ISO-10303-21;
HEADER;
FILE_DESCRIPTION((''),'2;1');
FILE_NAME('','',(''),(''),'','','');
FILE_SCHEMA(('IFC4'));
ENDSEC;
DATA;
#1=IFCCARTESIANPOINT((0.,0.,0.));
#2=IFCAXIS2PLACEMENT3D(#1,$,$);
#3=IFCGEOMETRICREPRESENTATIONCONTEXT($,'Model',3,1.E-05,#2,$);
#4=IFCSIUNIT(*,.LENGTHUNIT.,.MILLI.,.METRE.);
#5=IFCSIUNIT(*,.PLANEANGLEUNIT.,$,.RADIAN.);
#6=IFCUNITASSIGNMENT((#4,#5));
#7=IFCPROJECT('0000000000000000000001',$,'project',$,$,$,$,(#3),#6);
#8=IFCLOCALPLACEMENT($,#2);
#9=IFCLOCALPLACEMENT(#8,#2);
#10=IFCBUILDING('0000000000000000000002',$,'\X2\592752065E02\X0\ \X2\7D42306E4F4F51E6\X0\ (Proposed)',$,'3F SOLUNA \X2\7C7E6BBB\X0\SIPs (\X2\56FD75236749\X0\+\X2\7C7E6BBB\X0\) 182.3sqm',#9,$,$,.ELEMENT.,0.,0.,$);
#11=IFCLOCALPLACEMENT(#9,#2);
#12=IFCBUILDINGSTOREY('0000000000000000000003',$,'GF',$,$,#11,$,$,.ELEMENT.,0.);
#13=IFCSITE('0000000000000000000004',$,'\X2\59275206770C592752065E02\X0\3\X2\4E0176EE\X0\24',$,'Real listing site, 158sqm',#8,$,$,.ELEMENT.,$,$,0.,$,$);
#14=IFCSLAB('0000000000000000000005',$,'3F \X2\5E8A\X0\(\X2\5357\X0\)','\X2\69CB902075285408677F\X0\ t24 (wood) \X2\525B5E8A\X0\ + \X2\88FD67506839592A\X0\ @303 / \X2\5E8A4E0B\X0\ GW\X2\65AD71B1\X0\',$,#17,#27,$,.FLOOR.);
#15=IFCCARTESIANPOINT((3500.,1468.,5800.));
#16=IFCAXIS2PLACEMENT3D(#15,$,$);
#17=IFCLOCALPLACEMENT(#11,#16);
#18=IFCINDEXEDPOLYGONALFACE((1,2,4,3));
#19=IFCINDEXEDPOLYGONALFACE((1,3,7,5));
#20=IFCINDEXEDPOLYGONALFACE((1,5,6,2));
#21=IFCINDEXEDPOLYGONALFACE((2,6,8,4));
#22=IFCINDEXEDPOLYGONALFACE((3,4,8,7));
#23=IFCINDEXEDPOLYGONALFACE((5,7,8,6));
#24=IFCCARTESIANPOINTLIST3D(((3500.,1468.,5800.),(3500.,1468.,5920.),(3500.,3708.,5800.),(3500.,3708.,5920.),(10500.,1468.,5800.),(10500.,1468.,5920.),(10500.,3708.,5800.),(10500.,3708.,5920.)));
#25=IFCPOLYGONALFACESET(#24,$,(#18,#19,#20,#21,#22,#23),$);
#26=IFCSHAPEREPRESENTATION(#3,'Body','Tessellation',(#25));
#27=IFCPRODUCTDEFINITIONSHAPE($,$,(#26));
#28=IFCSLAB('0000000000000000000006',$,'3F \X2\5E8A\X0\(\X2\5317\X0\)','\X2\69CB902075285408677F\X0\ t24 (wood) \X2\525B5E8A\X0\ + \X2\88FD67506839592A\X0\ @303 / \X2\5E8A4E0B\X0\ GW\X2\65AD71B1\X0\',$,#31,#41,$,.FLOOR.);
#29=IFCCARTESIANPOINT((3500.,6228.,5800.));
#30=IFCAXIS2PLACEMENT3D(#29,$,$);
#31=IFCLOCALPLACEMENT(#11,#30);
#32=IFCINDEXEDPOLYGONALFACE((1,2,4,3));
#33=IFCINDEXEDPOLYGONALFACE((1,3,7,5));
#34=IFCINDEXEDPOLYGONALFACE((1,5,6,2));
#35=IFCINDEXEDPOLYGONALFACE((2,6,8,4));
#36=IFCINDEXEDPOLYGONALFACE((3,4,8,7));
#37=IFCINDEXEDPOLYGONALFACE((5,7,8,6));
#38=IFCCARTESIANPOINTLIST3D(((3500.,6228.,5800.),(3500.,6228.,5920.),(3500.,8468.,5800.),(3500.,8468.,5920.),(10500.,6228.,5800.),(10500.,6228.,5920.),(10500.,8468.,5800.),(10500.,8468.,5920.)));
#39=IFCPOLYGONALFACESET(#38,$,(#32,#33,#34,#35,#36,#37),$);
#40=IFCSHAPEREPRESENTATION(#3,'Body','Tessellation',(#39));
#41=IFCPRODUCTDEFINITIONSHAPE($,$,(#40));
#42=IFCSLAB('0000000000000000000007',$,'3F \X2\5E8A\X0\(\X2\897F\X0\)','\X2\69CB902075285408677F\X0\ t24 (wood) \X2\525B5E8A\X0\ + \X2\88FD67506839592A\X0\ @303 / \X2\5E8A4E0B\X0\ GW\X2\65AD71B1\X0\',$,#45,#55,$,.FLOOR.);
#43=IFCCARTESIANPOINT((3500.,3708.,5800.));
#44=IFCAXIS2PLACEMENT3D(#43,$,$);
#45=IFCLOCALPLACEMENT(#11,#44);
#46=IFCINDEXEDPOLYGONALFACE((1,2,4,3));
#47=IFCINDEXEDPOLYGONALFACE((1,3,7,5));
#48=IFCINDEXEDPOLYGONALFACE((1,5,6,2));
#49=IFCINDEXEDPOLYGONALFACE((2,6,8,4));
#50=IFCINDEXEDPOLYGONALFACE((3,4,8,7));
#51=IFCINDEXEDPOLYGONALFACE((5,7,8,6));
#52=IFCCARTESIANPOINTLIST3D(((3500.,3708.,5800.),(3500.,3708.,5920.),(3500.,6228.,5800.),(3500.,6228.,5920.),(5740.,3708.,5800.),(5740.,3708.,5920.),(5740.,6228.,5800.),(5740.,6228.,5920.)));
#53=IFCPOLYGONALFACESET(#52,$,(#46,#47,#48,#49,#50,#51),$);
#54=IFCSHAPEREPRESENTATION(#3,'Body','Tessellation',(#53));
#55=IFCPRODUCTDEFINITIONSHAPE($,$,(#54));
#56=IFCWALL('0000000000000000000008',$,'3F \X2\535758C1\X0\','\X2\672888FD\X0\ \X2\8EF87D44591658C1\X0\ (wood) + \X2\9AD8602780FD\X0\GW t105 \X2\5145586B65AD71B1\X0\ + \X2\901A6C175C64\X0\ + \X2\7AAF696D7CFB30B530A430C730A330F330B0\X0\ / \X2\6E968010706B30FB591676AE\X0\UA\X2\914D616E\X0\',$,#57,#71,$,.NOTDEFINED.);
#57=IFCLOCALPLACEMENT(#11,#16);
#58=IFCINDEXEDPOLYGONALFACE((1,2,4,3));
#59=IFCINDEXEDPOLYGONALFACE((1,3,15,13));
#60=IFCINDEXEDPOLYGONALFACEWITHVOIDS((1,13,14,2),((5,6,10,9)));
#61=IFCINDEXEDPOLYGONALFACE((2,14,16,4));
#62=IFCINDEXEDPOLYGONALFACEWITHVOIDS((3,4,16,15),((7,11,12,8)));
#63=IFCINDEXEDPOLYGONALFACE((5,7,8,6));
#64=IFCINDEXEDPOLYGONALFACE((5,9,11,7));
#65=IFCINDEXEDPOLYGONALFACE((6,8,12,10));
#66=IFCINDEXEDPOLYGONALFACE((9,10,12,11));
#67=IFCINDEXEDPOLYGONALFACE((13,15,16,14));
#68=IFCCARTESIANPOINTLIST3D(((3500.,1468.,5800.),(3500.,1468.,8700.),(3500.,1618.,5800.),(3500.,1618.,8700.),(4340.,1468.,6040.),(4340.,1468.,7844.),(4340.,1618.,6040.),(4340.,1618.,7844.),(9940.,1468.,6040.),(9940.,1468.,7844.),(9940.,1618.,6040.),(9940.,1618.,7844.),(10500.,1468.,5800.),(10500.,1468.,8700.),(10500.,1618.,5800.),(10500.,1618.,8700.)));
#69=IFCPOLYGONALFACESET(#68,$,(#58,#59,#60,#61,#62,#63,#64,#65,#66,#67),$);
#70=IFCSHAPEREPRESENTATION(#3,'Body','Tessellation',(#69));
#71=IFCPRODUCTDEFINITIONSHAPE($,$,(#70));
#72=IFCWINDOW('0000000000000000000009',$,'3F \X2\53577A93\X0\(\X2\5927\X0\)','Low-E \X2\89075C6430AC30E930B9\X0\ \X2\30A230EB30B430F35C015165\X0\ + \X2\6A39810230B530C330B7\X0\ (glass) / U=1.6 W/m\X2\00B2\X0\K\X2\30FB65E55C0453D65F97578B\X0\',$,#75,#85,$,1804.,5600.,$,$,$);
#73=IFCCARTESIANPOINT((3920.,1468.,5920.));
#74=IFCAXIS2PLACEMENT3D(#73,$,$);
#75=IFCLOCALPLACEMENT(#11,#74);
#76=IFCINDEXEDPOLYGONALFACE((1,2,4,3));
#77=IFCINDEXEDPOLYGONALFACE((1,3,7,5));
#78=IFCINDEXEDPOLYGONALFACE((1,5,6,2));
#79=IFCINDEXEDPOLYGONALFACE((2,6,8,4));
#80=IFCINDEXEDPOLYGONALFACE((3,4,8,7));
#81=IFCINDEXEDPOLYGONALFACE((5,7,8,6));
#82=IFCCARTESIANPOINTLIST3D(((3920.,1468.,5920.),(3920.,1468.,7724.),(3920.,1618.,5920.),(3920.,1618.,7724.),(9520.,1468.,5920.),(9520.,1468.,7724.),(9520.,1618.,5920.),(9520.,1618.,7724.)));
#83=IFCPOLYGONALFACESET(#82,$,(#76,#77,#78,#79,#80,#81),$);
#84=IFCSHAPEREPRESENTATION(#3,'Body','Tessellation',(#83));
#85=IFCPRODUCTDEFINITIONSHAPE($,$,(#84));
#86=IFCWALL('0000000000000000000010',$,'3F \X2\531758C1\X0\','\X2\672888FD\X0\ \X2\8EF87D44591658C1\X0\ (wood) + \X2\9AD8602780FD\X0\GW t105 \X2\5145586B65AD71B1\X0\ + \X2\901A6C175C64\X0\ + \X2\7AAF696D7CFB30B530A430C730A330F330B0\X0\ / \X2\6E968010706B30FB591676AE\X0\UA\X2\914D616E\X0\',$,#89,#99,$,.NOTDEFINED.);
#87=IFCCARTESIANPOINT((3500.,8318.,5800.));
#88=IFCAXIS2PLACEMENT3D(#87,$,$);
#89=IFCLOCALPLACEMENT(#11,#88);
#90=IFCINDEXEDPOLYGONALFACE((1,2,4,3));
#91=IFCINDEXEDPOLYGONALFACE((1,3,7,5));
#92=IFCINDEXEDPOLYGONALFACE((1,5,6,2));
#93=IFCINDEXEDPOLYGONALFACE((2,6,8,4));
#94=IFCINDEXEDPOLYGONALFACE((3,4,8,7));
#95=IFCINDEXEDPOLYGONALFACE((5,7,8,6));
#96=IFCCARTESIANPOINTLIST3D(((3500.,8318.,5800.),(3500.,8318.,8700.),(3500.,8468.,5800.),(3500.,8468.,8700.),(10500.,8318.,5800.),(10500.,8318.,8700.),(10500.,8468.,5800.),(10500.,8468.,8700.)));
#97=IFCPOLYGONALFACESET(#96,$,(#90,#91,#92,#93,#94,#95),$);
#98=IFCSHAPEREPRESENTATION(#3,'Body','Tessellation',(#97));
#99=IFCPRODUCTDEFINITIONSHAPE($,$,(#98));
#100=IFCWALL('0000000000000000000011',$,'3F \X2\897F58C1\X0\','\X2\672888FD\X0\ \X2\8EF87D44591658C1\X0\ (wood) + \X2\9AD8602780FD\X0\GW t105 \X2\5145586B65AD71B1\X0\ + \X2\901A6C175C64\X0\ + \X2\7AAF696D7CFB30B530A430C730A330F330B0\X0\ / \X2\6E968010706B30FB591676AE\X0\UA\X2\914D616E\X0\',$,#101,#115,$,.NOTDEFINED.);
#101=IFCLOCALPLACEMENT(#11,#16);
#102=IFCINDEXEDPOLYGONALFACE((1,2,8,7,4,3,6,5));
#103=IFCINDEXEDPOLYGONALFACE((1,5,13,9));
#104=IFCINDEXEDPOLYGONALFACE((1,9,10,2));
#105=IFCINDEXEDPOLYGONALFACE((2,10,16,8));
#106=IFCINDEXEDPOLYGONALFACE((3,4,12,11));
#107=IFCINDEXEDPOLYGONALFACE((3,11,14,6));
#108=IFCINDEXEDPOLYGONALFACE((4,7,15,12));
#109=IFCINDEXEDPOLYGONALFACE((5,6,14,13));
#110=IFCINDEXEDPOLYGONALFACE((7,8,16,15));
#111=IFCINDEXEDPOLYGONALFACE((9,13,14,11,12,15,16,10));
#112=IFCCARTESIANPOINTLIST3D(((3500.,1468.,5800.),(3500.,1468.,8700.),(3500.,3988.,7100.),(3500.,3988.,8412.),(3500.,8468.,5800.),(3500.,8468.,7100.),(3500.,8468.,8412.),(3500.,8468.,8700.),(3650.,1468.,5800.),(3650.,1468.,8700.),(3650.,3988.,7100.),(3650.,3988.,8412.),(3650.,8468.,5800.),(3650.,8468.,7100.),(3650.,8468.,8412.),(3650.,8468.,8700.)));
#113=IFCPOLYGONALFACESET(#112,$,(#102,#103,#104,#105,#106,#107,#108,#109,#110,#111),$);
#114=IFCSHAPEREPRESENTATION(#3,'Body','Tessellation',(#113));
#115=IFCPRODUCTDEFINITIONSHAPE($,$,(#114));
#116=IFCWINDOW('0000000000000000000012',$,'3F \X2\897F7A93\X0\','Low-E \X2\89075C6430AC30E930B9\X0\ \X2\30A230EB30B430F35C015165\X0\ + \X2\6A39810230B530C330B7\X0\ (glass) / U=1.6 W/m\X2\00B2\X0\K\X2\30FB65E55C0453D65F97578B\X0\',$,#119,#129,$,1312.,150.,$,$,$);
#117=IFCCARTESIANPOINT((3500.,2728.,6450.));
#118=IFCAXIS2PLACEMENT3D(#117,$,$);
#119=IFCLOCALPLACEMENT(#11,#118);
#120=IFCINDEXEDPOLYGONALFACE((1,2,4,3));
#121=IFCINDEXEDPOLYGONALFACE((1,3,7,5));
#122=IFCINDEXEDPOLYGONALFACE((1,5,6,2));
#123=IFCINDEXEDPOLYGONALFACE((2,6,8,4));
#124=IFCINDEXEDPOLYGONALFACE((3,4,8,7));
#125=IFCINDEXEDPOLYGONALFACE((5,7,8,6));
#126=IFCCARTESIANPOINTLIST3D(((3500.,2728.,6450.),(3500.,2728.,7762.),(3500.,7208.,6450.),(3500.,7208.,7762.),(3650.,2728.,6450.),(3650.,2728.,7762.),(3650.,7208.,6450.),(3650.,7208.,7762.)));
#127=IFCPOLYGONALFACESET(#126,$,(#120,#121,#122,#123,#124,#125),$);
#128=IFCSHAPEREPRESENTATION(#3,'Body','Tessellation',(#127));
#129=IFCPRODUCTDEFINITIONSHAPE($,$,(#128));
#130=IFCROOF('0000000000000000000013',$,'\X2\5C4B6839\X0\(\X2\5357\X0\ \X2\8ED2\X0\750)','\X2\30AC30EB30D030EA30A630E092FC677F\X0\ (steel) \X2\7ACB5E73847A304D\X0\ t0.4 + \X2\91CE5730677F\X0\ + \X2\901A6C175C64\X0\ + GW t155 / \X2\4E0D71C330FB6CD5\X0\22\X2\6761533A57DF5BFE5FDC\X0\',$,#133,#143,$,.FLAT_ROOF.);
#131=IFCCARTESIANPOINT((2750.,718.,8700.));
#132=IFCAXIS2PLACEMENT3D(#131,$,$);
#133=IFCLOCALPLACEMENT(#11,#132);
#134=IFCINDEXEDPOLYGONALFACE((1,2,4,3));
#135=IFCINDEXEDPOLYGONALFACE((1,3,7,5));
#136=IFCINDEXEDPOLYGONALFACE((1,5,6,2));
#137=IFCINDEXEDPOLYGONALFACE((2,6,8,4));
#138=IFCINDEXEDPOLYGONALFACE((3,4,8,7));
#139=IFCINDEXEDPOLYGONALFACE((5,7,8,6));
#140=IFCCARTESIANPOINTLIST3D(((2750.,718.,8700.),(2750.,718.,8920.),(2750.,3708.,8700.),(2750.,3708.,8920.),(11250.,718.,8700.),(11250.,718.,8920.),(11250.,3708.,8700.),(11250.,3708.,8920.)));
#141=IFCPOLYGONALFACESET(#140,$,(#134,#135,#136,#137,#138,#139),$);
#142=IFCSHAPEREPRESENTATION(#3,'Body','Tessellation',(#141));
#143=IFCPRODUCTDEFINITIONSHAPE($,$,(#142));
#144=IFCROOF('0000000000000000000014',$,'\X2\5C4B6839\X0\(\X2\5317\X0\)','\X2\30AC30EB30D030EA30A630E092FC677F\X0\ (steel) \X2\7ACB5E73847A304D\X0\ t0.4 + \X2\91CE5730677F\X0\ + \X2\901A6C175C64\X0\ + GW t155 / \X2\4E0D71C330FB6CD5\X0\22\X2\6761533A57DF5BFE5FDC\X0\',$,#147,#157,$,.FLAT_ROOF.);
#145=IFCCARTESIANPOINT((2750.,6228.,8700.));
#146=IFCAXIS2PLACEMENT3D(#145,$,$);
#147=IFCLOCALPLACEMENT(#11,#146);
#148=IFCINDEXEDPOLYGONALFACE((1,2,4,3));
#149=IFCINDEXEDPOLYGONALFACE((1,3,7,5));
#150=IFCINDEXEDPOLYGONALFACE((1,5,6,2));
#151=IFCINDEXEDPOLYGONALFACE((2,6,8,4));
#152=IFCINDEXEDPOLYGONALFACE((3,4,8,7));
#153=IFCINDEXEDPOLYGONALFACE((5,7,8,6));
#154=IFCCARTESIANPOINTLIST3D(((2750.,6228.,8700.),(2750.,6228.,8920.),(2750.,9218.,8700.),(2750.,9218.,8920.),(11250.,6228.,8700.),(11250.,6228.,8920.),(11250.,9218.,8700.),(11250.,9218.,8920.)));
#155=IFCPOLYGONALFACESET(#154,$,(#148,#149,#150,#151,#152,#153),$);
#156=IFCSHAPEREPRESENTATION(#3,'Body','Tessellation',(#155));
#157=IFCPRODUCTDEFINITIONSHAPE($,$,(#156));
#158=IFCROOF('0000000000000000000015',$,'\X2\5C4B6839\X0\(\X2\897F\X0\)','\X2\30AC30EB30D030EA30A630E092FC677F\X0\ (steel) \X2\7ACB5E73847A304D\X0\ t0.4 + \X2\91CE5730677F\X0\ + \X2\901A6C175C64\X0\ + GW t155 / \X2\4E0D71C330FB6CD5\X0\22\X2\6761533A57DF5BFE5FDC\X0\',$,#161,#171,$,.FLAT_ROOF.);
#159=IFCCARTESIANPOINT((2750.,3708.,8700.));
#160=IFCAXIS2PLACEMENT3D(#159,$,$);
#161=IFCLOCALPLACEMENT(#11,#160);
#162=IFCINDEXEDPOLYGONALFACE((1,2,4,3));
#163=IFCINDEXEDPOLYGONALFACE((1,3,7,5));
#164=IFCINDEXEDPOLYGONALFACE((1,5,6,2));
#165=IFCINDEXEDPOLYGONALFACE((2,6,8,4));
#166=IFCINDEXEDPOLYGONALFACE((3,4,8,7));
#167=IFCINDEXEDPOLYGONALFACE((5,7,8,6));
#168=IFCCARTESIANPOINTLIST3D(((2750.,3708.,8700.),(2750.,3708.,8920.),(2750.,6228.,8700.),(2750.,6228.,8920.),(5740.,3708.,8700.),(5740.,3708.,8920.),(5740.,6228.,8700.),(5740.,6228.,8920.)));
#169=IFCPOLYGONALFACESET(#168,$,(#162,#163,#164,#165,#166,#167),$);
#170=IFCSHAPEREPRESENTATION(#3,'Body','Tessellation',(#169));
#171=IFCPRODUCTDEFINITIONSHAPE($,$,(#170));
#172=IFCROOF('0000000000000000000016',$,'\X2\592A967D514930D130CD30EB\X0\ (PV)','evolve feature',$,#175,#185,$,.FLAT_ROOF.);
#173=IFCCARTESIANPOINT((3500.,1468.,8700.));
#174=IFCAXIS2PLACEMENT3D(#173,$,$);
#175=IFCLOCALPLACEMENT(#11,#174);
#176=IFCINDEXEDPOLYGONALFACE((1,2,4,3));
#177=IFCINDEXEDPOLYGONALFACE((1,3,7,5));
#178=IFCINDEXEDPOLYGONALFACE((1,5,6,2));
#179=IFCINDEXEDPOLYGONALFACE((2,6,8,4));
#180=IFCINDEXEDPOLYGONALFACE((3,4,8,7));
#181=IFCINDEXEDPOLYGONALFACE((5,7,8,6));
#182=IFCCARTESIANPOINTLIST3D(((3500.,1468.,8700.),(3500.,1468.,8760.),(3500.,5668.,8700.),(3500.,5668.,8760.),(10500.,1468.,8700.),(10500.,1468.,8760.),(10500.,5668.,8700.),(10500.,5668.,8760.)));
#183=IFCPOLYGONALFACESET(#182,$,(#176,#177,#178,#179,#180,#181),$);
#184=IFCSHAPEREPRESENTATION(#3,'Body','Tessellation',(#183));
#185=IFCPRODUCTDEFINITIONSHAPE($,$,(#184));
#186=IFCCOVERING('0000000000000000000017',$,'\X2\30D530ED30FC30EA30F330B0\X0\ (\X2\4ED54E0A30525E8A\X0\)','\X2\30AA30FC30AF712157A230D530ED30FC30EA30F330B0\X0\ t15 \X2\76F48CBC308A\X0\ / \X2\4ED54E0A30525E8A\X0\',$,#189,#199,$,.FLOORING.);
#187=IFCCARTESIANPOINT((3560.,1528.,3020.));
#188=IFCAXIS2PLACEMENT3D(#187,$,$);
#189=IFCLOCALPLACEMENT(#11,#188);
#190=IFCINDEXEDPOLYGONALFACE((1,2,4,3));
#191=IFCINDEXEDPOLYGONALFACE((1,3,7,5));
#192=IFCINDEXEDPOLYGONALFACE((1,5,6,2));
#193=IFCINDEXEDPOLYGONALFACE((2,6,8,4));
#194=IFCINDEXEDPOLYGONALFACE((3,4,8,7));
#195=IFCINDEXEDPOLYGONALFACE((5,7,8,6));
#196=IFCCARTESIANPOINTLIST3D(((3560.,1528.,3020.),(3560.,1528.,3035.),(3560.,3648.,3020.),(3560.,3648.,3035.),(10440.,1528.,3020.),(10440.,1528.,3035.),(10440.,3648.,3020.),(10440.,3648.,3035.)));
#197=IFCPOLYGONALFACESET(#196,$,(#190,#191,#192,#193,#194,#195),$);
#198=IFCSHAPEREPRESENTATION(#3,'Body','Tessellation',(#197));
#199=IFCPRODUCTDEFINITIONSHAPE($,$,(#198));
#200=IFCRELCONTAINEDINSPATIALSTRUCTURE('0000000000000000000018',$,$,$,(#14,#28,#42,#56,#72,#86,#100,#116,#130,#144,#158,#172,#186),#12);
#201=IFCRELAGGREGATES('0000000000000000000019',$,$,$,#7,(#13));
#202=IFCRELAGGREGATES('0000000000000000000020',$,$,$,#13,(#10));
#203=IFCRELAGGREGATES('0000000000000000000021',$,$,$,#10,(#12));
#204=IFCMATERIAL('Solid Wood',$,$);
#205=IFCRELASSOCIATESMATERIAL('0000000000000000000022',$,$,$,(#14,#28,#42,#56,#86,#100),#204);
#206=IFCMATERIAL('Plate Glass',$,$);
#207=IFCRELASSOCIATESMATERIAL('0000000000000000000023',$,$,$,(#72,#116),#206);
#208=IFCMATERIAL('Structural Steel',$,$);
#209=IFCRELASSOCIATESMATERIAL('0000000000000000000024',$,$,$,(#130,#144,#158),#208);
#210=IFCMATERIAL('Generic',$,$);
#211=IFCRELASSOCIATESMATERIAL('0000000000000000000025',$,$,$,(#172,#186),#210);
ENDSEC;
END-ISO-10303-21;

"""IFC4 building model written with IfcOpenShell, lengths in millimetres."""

from ifc_helpers import new_model, si_unit, frame, frame_2d, origin, place, context, project, spatial, rectangle, extrude, material, element, fill, save


model = new_model("IFC4")

# Units and contexts
model_context = context("Model", 3, precision=1e-05, world=origin())
ifc_project = project(units=[si_unit("LENGTHUNIT", "METRE", prefix="MILLI"), si_unit("PLANEANGLEUNIT", "RADIAN")], contexts=[model_context])

# Site, building, storey
site_placement = place(None, origin())
site = spatial("IfcSite", under=ifc_project, at=site_placement, Name="大分県大分市3丁目24", ObjectType="Real listing site, 158sqm", CompositionType="ELEMENT", RefElevation=0.0)
building_placement = place(site_placement, origin())
building = spatial("IfcBuilding", under=site, at=building_placement, Name="大分市 終の住処 (Proposed)", ObjectType="3F SOLUNA 籾殻SIPs (国産杉+籾殻) 182.3sqm", CompositionType="ELEMENT", ElevationOfRefHeight=0.0, ElevationOfTerrain=0.0)
storey_placement = place(building_placement, origin())
storey = spatial("IfcBuildingStorey", under=building, at=storey_placement, Name="GF", CompositionType="ELEMENT", Elevation=0.0)

# Slabs
ifc_material_1 = material(Name="Solid Wood")
slab_1_placement = place(storey_placement, frame((3500.0, 1468.0, 5800.0)))
element("IfcSlab", 1, at=slab_1_placement, inside=storey, material=ifc_material_1, Name="3F 床(南)", Description="構造用合板 t24 (wood) 剛床 + 製材根太 @303 / 床下 GW断熱", PredefinedType="FLOOR", context=model_context, shape_type="SweptSolid", body=[
    extrude(rectangle(XDim=7000.0, YDim=2240.0, at=frame_2d((3500.0, 1120.0))), frame((3500.0, 1468.0, 5800.0)), (0.0, 0.0, 1.0), 120.0),
])
slab_2_placement = place(storey_placement, frame((3500.0, 6228.0, 5800.0)))
element("IfcSlab", 2, at=slab_2_placement, inside=storey, material=ifc_material_1, Name="3F 床(北)", Description="構造用合板 t24 (wood) 剛床 + 製材根太 @303 / 床下 GW断熱", PredefinedType="FLOOR", context=model_context, shape_type="SweptSolid", body=[
    extrude(rectangle(XDim=7000.0, YDim=2240.0, at=frame_2d((3500.0, 1120.0))), frame((3500.0, 6228.0, 5800.0)), (0.0, 0.0, 1.0), 120.0),
])
slab_3_placement = place(storey_placement, frame((3500.0, 3708.0, 5800.0)))
element("IfcSlab", 3, at=slab_3_placement, inside=storey, material=ifc_material_1, Name="3F 床(西)", Description="構造用合板 t24 (wood) 剛床 + 製材根太 @303 / 床下 GW断熱", PredefinedType="FLOOR", context=model_context, shape_type="SweptSolid", body=[
    extrude(rectangle(XDim=2240.0, YDim=2520.0, at=frame_2d((1120.0, 1260.0))), frame((3500.0, 3708.0, 5800.0)), (0.0, 0.0, 1.0), 120.0),
])

# Wall, opening, window
wall_1_placement = place(storey_placement, frame((3500.0, 1468.0, 5800.0)))
wall_1 = element("IfcWall", 4, at=wall_1_placement, inside=storey, material=ifc_material_1, Name="3F 南壁", Description="木製 軸組外壁 (wood) + 高性能GW t105 充填断熱 + 通気層 + 窯業系サイディング / 準耐火・外皮UA配慮", PredefinedType="NOTDEFINED", context=model_context, shape_type="SweptSolid", body=[
    extrude(rectangle(XDim=7000.0, YDim=150.0, at=frame_2d((3500.0, 75.0))), frame((3500.0, 1468.0, 5800.0)), (0.0, 0.0, 1.0), 2900.0),
])
opening_1_placement = place(storey_placement, frame((3920.0, 1468.0, 5920.0)))
opening_1 = element("IfcOpeningElement", 5, at=opening_1_placement, cuts=wall_1, PredefinedType="NOTDEFINED", context=model_context, shape_type="SweptSolid", body=[
    extrude(rectangle(XDim=5600.0, YDim=150.0, at=frame_2d((2800.0, 75.0))), frame((3920.0, 1468.0, 5920.0)), (0.0, 0.0, 1.0), 1804.0),
])
ifc_material_2 = material(Name="Plate Glass")
window_1_placement = place(storey_placement, frame((3920.0, 1468.0, 5920.0)))
window_1 = element("IfcWindow", 6, at=window_1_placement, inside=storey, material=ifc_material_2, Name="3F 南窓(大)", Description="Low-E 複層ガラス アルゴン封入 + 樹脂サッシ (glass) / U=1.6 W/m²K・日射取得型", OverallHeight=1804.0, OverallWidth=5600.0, context=model_context, shape_type="SweptSolid", body=[
    extrude(rectangle(XDim=5600.0, YDim=150.0, at=frame_2d((2800.0, 75.0))), frame((3920.0, 1468.0, 5920.0)), (0.0, 0.0, 1.0), 1804.0),
])
fill(opening_1, window_1)

# Wall
wall_2_placement = place(storey_placement, frame((3500.0, 8318.0, 5800.0)))
element("IfcWall", 7, at=wall_2_placement, inside=storey, material=ifc_material_1, Name="3F 北壁", Description="木製 軸組外壁 (wood) + 高性能GW t105 充填断熱 + 通気層 + 窯業系サイディング / 準耐火・外皮UA配慮", PredefinedType="NOTDEFINED", context=model_context, shape_type="SweptSolid", body=[
    extrude(rectangle(XDim=7000.0, YDim=150.0, at=frame_2d((3500.0, 75.0))), frame((3500.0, 8318.0, 5800.0)), (0.0, 0.0, 1.0), 2900.0),
])

# Wall, opening, window
wall_3_placement = place(storey_placement, frame((3500.0, 1468.0, 5800.0)))
wall_3 = element("IfcWall", 8, at=wall_3_placement, inside=storey, material=ifc_material_1, Name="3F 西壁", Description="木製 軸組外壁 (wood) + 高性能GW t105 充填断熱 + 通気層 + 窯業系サイディング / 準耐火・外皮UA配慮", PredefinedType="NOTDEFINED", context=model_context, shape_type="SweptSolid", body=[
    extrude(rectangle(XDim=150.0, YDim=7000.0, at=frame_2d((75.0, 3500.0))), frame((3500.0, 1468.0, 5800.0)), (0.0, 0.0, 1.0), 2900.0),
])
opening_2_placement = place(storey_placement, frame((3500.0, 2728.0, 6450.0)))
opening_2 = element("IfcOpeningElement", 9, at=opening_2_placement, cuts=wall_3, PredefinedType="NOTDEFINED", context=model_context, shape_type="SweptSolid", body=[
    extrude(rectangle(XDim=150.0, YDim=4480.0, at=frame_2d((75.0, 2240.0))), frame((3500.0, 2728.0, 6450.0)), (0.0, 0.0, 1.0), 1312.0),
])
window_2_placement = place(storey_placement, frame((3500.0, 2728.0, 6450.0)))
window_2 = element("IfcWindow", 10, at=window_2_placement, inside=storey, material=ifc_material_2, Name="3F 西窓", Description="Low-E 複層ガラス アルゴン封入 + 樹脂サッシ (glass) / U=1.6 W/m²K・日射取得型", OverallHeight=1312.0, OverallWidth=150.0, context=model_context, shape_type="SweptSolid", body=[
    extrude(rectangle(XDim=150.0, YDim=4480.0, at=frame_2d((75.0, 2240.0))), frame((3500.0, 2728.0, 6450.0)), (0.0, 0.0, 1.0), 1312.0),
])
fill(opening_2, window_2)

# Roofs
ifc_material_3 = material(Name="Structural Steel")
roof_1_placement = place(storey_placement, frame((2750.0, 718.0, 8700.0)))
element("IfcRoof", 11, at=roof_1_placement, inside=storey, material=ifc_material_3, Name="屋根(南 軒750)", Description="ガルバリウム鋼板 (steel) 立平葺き t0.4 + 野地板 + 通気層 + GW t155 / 不燃・法22条区域対応", PredefinedType="FLAT_ROOF", context=model_context, shape_type="SweptSolid", body=[
    extrude(rectangle(XDim=8500.0, YDim=2990.0, at=frame_2d((4250.0, 1495.0))), frame((2750.0, 718.0, 8700.0)), (0.0, 0.0, 1.0), 220.0),
])
roof_2_placement = place(storey_placement, frame((2750.0, 6228.0, 8700.0)))
element("IfcRoof", 12, at=roof_2_placement, inside=storey, material=ifc_material_3, Name="屋根(北)", Description="ガルバリウム鋼板 (steel) 立平葺き t0.4 + 野地板 + 通気層 + GW t155 / 不燃・法22条区域対応", PredefinedType="FLAT_ROOF", context=model_context, shape_type="SweptSolid", body=[
    extrude(rectangle(XDim=8500.0, YDim=2990.0, at=frame_2d((4250.0, 1495.0))), frame((2750.0, 6228.0, 8700.0)), (0.0, 0.0, 1.0), 220.0),
])
roof_3_placement = place(storey_placement, frame((2750.0, 3708.0, 8700.0)))
element("IfcRoof", 13, at=roof_3_placement, inside=storey, material=ifc_material_3, Name="屋根(西)", Description="ガルバリウム鋼板 (steel) 立平葺き t0.4 + 野地板 + 通気層 + GW t155 / 不燃・法22条区域対応", PredefinedType="FLAT_ROOF", context=model_context, shape_type="SweptSolid", body=[
    extrude(rectangle(XDim=2990.0, YDim=2520.0, at=frame_2d((1495.0, 1260.0))), frame((2750.0, 3708.0, 8700.0)), (0.0, 0.0, 1.0), 220.0),
])
ifc_material_4 = material(Name="Generic")
roof_4_placement = place(storey_placement, frame((3500.0, 1468.0, 8700.0)))
element("IfcRoof", 14, at=roof_4_placement, inside=storey, material=ifc_material_4, Name="太陽光パネル (PV)", Description="evolve feature", PredefinedType="FLAT_ROOF", context=model_context, shape_type="SweptSolid", body=[
    extrude(rectangle(XDim=7000.0, YDim=4200.0, at=frame_2d((3500.0, 2100.0))), frame((3500.0, 1468.0, 8700.0)), (0.0, 0.0, 1.0), 60.0),
])

# Covering
covering_1_placement = place(storey_placement, frame((3560.0, 1528.0, 3020.0)))
element("IfcCovering", 15, at=covering_1_placement, inside=storey, material=ifc_material_4, Name="フローリング (仕上げ床)", Description="オーク無垢フローリング t15 直貼り / 仕上げ床", PredefinedType="FLOORING", context=model_context, shape_type="SweptSolid", body=[
    extrude(rectangle(XDim=6880.0, YDim=2120.0, at=frame_2d((3440.0, 1060.0))), frame((3560.0, 1528.0, 3020.0)), (0.0, 0.0, 1.0), 15.0),
])

save(model, "model.ifc")
